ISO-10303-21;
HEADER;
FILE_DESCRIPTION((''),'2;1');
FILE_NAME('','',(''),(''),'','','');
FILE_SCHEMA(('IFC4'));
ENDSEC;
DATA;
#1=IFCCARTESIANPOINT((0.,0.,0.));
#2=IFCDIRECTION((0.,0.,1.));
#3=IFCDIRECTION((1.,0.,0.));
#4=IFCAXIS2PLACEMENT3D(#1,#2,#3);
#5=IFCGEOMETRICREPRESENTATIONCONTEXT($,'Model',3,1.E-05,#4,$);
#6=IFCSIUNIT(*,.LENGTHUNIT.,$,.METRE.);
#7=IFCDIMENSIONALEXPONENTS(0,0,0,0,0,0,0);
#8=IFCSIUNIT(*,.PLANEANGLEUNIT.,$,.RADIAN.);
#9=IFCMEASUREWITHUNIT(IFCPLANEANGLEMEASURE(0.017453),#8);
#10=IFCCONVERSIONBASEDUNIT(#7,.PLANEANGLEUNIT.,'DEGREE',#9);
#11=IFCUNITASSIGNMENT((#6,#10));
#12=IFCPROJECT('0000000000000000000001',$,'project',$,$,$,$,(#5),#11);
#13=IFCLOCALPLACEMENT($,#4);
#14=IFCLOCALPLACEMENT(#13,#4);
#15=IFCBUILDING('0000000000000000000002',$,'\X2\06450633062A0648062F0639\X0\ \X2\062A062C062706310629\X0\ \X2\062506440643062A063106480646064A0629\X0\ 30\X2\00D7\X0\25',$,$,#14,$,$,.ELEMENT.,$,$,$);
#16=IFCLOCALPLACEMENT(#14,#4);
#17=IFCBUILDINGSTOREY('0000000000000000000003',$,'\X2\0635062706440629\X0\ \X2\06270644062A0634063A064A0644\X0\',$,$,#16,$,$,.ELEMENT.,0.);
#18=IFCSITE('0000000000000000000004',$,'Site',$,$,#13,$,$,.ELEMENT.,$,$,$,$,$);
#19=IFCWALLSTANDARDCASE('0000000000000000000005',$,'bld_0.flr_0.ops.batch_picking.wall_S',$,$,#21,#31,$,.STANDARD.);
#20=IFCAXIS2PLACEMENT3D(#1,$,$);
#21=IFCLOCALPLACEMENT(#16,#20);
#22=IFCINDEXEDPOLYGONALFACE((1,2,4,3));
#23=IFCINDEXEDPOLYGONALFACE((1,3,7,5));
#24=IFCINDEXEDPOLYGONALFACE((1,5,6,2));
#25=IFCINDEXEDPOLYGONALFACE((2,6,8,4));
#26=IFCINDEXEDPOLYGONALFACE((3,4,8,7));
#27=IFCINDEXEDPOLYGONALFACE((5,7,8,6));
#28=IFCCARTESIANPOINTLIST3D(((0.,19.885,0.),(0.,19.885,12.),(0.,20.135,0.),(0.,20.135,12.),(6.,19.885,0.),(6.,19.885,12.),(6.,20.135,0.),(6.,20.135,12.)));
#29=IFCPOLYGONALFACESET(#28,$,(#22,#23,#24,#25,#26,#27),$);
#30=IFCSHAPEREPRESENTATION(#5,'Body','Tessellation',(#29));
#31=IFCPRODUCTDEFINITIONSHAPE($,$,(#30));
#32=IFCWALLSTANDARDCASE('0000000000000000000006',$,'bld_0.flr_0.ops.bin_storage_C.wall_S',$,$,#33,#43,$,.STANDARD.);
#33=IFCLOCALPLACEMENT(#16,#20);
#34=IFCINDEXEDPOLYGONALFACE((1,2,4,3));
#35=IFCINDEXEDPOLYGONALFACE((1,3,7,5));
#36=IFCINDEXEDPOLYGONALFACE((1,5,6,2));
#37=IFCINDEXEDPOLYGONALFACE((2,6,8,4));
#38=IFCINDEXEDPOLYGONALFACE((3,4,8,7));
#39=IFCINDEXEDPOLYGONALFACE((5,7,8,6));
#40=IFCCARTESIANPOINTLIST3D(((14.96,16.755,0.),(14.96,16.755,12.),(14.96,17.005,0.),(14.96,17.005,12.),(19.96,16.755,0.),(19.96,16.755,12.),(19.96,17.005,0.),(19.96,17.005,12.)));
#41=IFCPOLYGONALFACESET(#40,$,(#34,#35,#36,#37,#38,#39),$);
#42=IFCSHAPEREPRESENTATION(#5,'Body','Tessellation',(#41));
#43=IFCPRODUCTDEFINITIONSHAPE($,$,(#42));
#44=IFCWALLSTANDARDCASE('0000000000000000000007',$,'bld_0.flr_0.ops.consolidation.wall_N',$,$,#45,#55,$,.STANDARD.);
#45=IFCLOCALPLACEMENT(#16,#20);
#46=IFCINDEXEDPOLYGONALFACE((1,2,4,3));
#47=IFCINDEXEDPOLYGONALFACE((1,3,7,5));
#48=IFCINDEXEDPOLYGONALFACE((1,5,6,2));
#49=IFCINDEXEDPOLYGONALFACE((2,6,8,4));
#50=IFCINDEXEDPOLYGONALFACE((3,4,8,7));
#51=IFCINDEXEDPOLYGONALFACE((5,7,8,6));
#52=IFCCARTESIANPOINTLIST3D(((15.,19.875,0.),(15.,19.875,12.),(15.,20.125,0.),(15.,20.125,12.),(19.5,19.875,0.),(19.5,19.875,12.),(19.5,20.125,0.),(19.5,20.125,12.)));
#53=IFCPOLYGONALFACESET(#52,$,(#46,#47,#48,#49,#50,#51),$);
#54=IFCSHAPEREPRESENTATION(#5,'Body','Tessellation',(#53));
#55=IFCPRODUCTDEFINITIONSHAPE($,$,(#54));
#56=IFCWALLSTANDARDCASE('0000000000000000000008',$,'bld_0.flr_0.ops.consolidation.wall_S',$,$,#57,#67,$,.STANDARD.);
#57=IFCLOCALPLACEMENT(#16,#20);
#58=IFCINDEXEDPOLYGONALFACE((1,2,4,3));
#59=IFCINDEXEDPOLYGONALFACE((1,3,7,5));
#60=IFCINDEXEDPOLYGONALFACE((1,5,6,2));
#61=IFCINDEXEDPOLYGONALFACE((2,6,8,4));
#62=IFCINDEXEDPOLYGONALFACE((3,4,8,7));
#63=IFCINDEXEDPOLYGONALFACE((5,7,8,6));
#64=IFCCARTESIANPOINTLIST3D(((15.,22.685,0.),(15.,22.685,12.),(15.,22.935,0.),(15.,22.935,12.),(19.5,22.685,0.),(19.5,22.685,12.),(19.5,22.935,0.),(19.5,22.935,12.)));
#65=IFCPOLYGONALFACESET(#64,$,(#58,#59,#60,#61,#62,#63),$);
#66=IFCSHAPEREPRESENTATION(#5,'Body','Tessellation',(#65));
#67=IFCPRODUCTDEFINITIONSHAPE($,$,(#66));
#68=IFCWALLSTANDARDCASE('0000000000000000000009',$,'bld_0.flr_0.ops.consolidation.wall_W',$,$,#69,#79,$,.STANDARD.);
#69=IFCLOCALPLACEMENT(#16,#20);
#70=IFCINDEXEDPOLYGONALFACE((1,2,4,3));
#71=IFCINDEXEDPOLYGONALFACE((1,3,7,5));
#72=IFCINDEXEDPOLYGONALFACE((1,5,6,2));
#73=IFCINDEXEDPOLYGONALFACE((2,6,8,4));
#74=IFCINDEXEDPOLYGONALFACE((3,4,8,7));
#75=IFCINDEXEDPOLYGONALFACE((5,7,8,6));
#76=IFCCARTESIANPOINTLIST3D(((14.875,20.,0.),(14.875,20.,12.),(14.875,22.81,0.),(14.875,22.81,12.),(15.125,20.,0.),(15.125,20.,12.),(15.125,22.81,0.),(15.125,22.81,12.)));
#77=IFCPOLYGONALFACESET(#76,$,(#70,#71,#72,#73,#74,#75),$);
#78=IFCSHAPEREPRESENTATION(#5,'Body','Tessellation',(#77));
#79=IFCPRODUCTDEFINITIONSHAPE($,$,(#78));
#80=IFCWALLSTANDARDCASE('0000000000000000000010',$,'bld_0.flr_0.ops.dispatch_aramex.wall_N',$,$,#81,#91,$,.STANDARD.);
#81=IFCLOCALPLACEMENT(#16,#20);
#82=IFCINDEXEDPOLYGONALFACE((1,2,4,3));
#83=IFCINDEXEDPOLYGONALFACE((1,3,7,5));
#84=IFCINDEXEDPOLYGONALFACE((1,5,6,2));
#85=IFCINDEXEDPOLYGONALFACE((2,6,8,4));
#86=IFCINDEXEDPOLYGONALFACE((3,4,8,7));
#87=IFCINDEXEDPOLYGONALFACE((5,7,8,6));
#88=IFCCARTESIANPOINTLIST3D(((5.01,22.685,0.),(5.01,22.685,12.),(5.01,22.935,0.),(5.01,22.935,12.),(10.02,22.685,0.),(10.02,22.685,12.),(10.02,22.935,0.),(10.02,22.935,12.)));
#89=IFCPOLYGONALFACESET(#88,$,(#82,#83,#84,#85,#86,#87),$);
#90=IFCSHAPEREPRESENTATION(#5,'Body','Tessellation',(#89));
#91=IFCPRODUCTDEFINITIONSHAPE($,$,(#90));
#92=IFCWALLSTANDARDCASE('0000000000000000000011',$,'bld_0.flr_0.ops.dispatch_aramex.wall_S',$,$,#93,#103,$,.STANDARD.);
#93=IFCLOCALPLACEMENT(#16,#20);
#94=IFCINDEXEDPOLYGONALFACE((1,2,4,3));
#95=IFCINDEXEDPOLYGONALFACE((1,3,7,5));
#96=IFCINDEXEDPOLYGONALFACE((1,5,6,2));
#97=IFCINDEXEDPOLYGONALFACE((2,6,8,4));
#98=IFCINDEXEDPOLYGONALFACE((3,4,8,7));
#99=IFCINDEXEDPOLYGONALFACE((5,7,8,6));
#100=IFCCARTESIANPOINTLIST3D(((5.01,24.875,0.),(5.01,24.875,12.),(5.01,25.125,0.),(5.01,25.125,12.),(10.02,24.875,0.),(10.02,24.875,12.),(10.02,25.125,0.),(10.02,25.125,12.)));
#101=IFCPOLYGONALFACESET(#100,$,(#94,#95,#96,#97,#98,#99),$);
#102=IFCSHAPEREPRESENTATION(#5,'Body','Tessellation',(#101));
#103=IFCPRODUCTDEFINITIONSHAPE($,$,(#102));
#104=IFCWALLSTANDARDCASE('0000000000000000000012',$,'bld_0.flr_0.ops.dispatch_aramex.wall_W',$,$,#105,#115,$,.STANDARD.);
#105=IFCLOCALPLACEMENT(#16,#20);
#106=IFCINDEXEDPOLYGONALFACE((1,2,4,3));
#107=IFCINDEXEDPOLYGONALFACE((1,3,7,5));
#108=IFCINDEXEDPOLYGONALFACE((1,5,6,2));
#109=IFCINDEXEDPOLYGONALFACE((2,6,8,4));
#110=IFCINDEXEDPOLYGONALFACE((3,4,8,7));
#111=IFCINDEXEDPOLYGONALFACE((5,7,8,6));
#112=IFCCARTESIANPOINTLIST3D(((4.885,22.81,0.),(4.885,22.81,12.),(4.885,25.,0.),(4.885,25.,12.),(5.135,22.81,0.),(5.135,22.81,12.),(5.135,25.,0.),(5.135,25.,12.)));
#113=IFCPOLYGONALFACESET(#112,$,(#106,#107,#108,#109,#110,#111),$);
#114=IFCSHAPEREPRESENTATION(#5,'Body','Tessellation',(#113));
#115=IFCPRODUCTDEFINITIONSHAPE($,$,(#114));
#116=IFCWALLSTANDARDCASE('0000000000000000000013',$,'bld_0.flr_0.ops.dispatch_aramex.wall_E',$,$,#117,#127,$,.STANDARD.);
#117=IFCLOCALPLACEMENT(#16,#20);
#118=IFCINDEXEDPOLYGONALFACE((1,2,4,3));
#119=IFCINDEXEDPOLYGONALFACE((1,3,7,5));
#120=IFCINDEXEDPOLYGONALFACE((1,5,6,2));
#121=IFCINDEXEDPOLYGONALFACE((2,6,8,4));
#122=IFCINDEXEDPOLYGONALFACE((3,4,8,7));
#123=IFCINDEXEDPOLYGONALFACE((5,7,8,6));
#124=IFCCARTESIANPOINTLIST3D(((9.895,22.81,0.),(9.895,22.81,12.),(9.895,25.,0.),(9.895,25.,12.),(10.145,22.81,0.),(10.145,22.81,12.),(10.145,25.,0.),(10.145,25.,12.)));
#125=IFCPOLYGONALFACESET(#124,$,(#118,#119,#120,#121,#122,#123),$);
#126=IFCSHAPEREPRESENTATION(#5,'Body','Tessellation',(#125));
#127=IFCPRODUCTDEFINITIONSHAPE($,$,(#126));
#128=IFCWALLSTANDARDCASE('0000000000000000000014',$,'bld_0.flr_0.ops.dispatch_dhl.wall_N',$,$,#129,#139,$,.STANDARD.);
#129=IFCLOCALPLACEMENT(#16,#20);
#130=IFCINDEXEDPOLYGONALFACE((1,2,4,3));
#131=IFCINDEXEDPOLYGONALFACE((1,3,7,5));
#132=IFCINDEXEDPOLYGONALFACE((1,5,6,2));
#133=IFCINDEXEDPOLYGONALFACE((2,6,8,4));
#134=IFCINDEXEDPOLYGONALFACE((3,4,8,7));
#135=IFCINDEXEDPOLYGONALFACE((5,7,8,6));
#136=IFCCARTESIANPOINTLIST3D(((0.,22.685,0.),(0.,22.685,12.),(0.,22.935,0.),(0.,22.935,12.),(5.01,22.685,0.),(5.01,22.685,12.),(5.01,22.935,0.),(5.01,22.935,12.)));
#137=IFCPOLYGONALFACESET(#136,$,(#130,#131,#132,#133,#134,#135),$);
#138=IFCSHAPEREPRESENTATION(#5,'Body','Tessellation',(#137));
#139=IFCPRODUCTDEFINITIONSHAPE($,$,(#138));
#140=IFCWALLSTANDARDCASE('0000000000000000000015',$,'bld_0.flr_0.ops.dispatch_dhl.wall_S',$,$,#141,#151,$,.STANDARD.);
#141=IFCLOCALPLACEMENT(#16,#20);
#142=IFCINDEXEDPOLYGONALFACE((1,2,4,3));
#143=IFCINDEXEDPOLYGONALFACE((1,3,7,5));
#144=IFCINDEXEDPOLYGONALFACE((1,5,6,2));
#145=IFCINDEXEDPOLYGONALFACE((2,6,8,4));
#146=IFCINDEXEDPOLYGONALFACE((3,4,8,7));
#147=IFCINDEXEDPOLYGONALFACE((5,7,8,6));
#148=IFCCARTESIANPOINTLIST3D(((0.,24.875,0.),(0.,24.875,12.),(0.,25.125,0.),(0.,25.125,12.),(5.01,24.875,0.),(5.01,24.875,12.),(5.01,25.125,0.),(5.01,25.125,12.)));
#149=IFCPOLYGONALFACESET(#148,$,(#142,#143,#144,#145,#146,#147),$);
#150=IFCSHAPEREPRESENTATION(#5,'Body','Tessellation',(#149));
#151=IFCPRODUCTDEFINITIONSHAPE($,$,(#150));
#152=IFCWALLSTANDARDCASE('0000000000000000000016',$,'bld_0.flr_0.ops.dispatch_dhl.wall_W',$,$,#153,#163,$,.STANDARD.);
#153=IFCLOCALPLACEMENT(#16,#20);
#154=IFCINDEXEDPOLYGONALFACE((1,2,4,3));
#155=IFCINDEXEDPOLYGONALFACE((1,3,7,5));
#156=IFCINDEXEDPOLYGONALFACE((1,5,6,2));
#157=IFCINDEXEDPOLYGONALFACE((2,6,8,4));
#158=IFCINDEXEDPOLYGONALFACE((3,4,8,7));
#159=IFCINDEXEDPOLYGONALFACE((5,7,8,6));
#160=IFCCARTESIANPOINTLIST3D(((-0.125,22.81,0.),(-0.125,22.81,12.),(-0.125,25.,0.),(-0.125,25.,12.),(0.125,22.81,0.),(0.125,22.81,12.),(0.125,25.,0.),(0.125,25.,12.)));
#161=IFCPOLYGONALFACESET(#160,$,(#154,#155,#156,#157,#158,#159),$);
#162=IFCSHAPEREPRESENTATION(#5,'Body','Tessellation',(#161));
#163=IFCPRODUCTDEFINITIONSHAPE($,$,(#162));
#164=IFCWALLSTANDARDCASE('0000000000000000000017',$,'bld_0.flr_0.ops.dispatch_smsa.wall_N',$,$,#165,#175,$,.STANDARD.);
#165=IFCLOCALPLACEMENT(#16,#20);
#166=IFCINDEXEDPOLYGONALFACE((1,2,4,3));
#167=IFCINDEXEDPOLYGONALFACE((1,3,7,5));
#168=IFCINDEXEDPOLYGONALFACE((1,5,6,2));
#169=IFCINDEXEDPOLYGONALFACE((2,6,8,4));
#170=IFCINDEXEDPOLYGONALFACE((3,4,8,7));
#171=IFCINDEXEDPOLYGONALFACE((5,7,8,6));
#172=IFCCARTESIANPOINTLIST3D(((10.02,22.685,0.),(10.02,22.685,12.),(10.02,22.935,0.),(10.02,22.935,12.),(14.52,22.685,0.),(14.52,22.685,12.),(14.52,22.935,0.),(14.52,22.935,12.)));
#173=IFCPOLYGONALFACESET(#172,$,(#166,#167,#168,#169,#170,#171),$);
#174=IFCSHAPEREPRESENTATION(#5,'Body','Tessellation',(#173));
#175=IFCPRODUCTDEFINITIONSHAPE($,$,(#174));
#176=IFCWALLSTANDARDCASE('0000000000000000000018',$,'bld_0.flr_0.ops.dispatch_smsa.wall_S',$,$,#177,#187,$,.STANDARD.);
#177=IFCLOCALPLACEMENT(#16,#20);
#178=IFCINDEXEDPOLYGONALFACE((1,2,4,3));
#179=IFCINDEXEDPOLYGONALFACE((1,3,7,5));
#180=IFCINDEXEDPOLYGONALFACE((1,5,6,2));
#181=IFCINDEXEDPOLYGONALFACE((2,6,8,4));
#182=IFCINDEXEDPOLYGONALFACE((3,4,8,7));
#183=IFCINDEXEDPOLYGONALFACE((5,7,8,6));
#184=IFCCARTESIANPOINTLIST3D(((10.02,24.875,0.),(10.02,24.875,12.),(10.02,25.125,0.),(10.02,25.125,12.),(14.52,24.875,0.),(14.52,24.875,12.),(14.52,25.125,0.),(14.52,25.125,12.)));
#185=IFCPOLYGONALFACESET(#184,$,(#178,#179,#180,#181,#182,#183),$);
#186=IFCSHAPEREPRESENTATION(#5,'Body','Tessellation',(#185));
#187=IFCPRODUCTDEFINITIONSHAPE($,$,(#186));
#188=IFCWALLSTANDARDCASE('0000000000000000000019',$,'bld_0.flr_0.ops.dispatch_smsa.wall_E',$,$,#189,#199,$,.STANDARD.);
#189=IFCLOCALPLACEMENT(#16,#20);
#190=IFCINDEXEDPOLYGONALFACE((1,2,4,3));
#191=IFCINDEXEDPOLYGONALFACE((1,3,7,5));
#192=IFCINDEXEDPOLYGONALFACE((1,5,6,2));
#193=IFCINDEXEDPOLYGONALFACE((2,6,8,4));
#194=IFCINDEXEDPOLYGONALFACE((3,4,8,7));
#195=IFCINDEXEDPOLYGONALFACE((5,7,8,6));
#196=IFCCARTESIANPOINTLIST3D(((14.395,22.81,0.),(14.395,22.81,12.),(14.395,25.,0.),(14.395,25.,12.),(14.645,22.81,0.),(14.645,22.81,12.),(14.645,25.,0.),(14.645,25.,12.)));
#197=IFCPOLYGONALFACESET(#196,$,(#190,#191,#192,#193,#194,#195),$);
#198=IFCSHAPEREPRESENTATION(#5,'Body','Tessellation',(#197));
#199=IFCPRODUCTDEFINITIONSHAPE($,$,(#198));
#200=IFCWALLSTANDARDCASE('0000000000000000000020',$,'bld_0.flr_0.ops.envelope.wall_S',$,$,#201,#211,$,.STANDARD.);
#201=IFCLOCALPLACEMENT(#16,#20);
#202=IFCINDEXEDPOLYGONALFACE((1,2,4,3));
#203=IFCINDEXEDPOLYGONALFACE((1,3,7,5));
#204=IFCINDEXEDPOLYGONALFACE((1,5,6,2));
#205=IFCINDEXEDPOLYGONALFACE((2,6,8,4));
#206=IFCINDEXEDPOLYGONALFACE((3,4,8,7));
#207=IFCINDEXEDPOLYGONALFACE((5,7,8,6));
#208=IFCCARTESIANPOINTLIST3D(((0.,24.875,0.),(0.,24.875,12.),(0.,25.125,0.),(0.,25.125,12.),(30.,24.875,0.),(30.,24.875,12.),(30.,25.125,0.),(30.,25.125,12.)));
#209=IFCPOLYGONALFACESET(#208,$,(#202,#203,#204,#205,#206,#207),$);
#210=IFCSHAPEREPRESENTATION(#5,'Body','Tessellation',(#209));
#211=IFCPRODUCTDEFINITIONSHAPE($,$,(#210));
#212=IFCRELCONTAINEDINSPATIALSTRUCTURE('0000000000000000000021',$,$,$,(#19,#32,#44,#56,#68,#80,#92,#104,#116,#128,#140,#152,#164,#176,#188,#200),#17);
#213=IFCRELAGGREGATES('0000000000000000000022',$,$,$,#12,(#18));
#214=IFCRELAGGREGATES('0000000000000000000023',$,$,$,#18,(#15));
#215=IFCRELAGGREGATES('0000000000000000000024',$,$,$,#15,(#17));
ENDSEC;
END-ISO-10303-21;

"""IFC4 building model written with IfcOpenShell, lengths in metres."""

from ifc_helpers import new_model, entity, si_unit, converted_unit, frame, frame_2d, origin_with_axes, place, context, project, spatial, rectangle, extrude, element, save


model = new_model("IFC4")

# Units and contexts
model_context = context("Model", 3, precision=1e-05, world=origin_with_axes())
ifc_project = project(units=[si_unit("LENGTHUNIT", "METRE"), converted_unit("PLANEANGLEUNIT", "DEGREE", entity("IfcPlaneAngleMeasure", 0.017453), si_unit("PLANEANGLEUNIT", "RADIAN"), dimensions=[0, 0, 0, 0, 0, 0, 0])], contexts=[model_context])

# Site, building, storey
site_placement = place(None, origin_with_axes())
site = spatial("IfcSite", under=ifc_project, at=site_placement, Name="Site", CompositionType="ELEMENT")
building_placement = place(site_placement, origin_with_axes())
building = spatial("IfcBuilding", under=site, at=building_placement, Name="مستودع تجارة إلكترونية 30×25", CompositionType="ELEMENT")
storey_placement = place(building_placement, origin_with_axes())
storey = spatial("IfcBuildingStorey", under=building, at=storey_placement, Name="صالة التشغيل", CompositionType="ELEMENT", Elevation=0.0)

# Walls
wall_1_placement = place(storey_placement, frame((0.0, 20.01, 0.0), z_axis=(0.0, 0.0, 1.0), x_axis=(1.0, 0.0, 0.0)))
element("IfcWallStandardCase", 1, at=wall_1_placement, inside=storey, Name="bld_0.flr_0.ops.batch_picking.wall_S", PredefinedType="STANDARD", context=model_context, shape_type="SweptSolid", body=[
    extrude(rectangle(XDim=6.0, YDim=0.25, at=frame_2d((3.0, 0.0), x_axis=(1.0, 0.0))), origin_with_axes(), (0.0, 0.0, 1.0), 12.0),
])
wall_2_placement = place(storey_placement, frame((14.96, 16.88, 0.0), z_axis=(0.0, 0.0, 1.0), x_axis=(1.0, 0.0, 0.0)))
element("IfcWallStandardCase", 2, at=wall_2_placement, inside=storey, Name="bld_0.flr_0.ops.bin_storage_C.wall_S", PredefinedType="STANDARD", context=model_context, shape_type="SweptSolid", body=[
    extrude(rectangle(XDim=5.0, YDim=0.25, at=frame_2d((2.5, 0.0), x_axis=(1.0, 0.0))), origin_with_axes(), (0.0, 0.0, 1.0), 12.0),
])
for number, where, z_axis, x_axis, name in (
    (3, (15.0, 20.0, 0.0), (0.0, 0.0, 1.0), (1.0, 0.0, 0.0), "bld_0.flr_0.ops.consolidation.wall_N"),
    (4, (15.0, 22.81, 0.0), (0.0, 0.0, 1.0), (1.0, 0.0, 0.0), "bld_0.flr_0.ops.consolidation.wall_S"),
):
    element("IfcWallStandardCase", number, at=place(storey_placement, frame(where, z_axis=z_axis, x_axis=x_axis)), inside=storey, Name=name, PredefinedType="STANDARD", context=model_context, shape_type="SweptSolid", body=[
        extrude(rectangle(XDim=4.5, YDim=0.25, at=frame_2d((2.25, 0.0), x_axis=(1.0, 0.0))), origin_with_axes(), (0.0, 0.0, 1.0), 12.0),
    ])
wall_3_placement = place(storey_placement, frame((15.0, 20.0, 0.0), z_axis=(0.0, 0.0, 1.0), x_axis=(0.0, 1.0, 0.0)))
element("IfcWallStandardCase", 5, at=wall_3_placement, inside=storey, Name="bld_0.flr_0.ops.consolidation.wall_W", PredefinedType="STANDARD", context=model_context, shape_type="SweptSolid", body=[
    extrude(rectangle(XDim=2.81, YDim=0.25, at=frame_2d((1.405, 0.0), x_axis=(1.0, 0.0))), origin_with_axes(), (0.0, 0.0, 1.0), 12.0),
])
for number, where, z_axis, x_axis, name in (
    (6, (5.01, 22.81, 0.0), (0.0, 0.0, 1.0), (1.0, 0.0, 0.0), "bld_0.flr_0.ops.dispatch_aramex.wall_N"),
    (7, (5.01, 25.0, 0.0), (0.0, 0.0, 1.0), (1.0, 0.0, 0.0), "bld_0.flr_0.ops.dispatch_aramex.wall_S"),
):
    element("IfcWallStandardCase", number, at=place(storey_placement, frame(where, z_axis=z_axis, x_axis=x_axis)), inside=storey, Name=name, PredefinedType="STANDARD", context=model_context, shape_type="SweptSolid", body=[
        extrude(rectangle(XDim=5.01, YDim=0.25, at=frame_2d((2.505, 0.0), x_axis=(1.0, 0.0))), origin_with_axes(), (0.0, 0.0, 1.0), 12.0),
    ])
for number, where, z_axis, x_axis, name in (
    (8, (5.01, 22.81, 0.0), (0.0, 0.0, 1.0), (0.0, 1.0, 0.0), "bld_0.flr_0.ops.dispatch_aramex.wall_W"),
    (9, (10.02, 22.81, 0.0), (0.0, 0.0, 1.0), (0.0, 1.0, 0.0), "bld_0.flr_0.ops.dispatch_aramex.wall_E"),
):
    element("IfcWallStandardCase", number, at=place(storey_placement, frame(where, z_axis=z_axis, x_axis=x_axis)), inside=storey, Name=name, PredefinedType="STANDARD", context=model_context, shape_type="SweptSolid", body=[
        extrude(rectangle(XDim=2.19, YDim=0.25, at=frame_2d((1.095, 0.0), x_axis=(1.0, 0.0))), origin_with_axes(), (0.0, 0.0, 1.0), 12.0),
    ])
for number, where, z_axis, x_axis, name in (
    (10, (0.0, 22.81, 0.0), (0.0, 0.0, 1.0), (1.0, 0.0, 0.0), "bld_0.flr_0.ops.dispatch_dhl.wall_N"),
    (11, (0.0, 25.0, 0.0), (0.0, 0.0, 1.0), (1.0, 0.0, 0.0), "bld_0.flr_0.ops.dispatch_dhl.wall_S"),
):
    element("IfcWallStandardCase", number, at=place(storey_placement, frame(where, z_axis=z_axis, x_axis=x_axis)), inside=storey, Name=name, PredefinedType="STANDARD", context=model_context, shape_type="SweptSolid", body=[
        extrude(rectangle(XDim=5.01, YDim=0.25, at=frame_2d((2.505, 0.0), x_axis=(1.0, 0.0))), origin_with_axes(), (0.0, 0.0, 1.0), 12.0),
    ])
for number, where, z_axis, x_axis, name in (
    (12, (0.0, 22.81, 0.0), (0.0, 0.0, 1.0), (0.0, 1.0, 0.0), "bld_0.flr_0.ops.dispatch_dhl.wall_W"),
):
    element("IfcWallStandardCase", number, at=place(storey_placement, frame(where, z_axis=z_axis, x_axis=x_axis)), inside=storey, Name=name, PredefinedType="STANDARD", context=model_context, shape_type="SweptSolid", body=[
        extrude(rectangle(XDim=2.19, YDim=0.25, at=frame_2d((1.095, 0.0), x_axis=(1.0, 0.0))), origin_with_axes(), (0.0, 0.0, 1.0), 12.0),
    ])
for number, where, z_axis, x_axis, name in (
    (13, (10.02, 22.81, 0.0), (0.0, 0.0, 1.0), (1.0, 0.0, 0.0), "bld_0.flr_0.ops.dispatch_smsa.wall_N"),
    (14, (10.02, 25.0, 0.0), (0.0, 0.0, 1.0), (1.0, 0.0, 0.0), "bld_0.flr_0.ops.dispatch_smsa.wall_S"),
):
    element("IfcWallStandardCase", number, at=place(storey_placement, frame(where, z_axis=z_axis, x_axis=x_axis)), inside=storey, Name=name, PredefinedType="STANDARD", context=model_context, shape_type="SweptSolid", body=[
        extrude(rectangle(XDim=4.5, YDim=0.25, at=frame_2d((2.25, 0.0), x_axis=(1.0, 0.0))), origin_with_axes(), (0.0, 0.0, 1.0), 12.0),
    ])
for number, where, z_axis, x_axis, name in (
    (15, (14.52, 22.81, 0.0), (0.0, 0.0, 1.0), (0.0, 1.0, 0.0), "bld_0.flr_0.ops.dispatch_smsa.wall_E"),
):
    element("IfcWallStandardCase", number, at=place(storey_placement, frame(where, z_axis=z_axis, x_axis=x_axis)), inside=storey, Name=name, PredefinedType="STANDARD", context=model_context, shape_type="SweptSolid", body=[
        extrude(rectangle(XDim=2.19, YDim=0.25, at=frame_2d((1.095, 0.0), x_axis=(1.0, 0.0))), origin_with_axes(), (0.0, 0.0, 1.0), 12.0),
    ])
wall_4_placement = place(storey_placement, frame((0.0, 25.0, 0.0), z_axis=(0.0, 0.0, 1.0), x_axis=(1.0, 0.0, 0.0)))
element("IfcWallStandardCase", 16, at=wall_4_placement, inside=storey, Name="bld_0.flr_0.ops.envelope.wall_S", PredefinedType="STANDARD", context=model_context, shape_type="SweptSolid", body=[
    extrude(rectangle(XDim=30.0, YDim=0.25, at=frame_2d((15.0, 0.0), x_axis=(1.0, 0.0))), origin_with_axes(), (0.0, 0.0, 1.0), 12.0),
])

save(model, "model.ifc")
